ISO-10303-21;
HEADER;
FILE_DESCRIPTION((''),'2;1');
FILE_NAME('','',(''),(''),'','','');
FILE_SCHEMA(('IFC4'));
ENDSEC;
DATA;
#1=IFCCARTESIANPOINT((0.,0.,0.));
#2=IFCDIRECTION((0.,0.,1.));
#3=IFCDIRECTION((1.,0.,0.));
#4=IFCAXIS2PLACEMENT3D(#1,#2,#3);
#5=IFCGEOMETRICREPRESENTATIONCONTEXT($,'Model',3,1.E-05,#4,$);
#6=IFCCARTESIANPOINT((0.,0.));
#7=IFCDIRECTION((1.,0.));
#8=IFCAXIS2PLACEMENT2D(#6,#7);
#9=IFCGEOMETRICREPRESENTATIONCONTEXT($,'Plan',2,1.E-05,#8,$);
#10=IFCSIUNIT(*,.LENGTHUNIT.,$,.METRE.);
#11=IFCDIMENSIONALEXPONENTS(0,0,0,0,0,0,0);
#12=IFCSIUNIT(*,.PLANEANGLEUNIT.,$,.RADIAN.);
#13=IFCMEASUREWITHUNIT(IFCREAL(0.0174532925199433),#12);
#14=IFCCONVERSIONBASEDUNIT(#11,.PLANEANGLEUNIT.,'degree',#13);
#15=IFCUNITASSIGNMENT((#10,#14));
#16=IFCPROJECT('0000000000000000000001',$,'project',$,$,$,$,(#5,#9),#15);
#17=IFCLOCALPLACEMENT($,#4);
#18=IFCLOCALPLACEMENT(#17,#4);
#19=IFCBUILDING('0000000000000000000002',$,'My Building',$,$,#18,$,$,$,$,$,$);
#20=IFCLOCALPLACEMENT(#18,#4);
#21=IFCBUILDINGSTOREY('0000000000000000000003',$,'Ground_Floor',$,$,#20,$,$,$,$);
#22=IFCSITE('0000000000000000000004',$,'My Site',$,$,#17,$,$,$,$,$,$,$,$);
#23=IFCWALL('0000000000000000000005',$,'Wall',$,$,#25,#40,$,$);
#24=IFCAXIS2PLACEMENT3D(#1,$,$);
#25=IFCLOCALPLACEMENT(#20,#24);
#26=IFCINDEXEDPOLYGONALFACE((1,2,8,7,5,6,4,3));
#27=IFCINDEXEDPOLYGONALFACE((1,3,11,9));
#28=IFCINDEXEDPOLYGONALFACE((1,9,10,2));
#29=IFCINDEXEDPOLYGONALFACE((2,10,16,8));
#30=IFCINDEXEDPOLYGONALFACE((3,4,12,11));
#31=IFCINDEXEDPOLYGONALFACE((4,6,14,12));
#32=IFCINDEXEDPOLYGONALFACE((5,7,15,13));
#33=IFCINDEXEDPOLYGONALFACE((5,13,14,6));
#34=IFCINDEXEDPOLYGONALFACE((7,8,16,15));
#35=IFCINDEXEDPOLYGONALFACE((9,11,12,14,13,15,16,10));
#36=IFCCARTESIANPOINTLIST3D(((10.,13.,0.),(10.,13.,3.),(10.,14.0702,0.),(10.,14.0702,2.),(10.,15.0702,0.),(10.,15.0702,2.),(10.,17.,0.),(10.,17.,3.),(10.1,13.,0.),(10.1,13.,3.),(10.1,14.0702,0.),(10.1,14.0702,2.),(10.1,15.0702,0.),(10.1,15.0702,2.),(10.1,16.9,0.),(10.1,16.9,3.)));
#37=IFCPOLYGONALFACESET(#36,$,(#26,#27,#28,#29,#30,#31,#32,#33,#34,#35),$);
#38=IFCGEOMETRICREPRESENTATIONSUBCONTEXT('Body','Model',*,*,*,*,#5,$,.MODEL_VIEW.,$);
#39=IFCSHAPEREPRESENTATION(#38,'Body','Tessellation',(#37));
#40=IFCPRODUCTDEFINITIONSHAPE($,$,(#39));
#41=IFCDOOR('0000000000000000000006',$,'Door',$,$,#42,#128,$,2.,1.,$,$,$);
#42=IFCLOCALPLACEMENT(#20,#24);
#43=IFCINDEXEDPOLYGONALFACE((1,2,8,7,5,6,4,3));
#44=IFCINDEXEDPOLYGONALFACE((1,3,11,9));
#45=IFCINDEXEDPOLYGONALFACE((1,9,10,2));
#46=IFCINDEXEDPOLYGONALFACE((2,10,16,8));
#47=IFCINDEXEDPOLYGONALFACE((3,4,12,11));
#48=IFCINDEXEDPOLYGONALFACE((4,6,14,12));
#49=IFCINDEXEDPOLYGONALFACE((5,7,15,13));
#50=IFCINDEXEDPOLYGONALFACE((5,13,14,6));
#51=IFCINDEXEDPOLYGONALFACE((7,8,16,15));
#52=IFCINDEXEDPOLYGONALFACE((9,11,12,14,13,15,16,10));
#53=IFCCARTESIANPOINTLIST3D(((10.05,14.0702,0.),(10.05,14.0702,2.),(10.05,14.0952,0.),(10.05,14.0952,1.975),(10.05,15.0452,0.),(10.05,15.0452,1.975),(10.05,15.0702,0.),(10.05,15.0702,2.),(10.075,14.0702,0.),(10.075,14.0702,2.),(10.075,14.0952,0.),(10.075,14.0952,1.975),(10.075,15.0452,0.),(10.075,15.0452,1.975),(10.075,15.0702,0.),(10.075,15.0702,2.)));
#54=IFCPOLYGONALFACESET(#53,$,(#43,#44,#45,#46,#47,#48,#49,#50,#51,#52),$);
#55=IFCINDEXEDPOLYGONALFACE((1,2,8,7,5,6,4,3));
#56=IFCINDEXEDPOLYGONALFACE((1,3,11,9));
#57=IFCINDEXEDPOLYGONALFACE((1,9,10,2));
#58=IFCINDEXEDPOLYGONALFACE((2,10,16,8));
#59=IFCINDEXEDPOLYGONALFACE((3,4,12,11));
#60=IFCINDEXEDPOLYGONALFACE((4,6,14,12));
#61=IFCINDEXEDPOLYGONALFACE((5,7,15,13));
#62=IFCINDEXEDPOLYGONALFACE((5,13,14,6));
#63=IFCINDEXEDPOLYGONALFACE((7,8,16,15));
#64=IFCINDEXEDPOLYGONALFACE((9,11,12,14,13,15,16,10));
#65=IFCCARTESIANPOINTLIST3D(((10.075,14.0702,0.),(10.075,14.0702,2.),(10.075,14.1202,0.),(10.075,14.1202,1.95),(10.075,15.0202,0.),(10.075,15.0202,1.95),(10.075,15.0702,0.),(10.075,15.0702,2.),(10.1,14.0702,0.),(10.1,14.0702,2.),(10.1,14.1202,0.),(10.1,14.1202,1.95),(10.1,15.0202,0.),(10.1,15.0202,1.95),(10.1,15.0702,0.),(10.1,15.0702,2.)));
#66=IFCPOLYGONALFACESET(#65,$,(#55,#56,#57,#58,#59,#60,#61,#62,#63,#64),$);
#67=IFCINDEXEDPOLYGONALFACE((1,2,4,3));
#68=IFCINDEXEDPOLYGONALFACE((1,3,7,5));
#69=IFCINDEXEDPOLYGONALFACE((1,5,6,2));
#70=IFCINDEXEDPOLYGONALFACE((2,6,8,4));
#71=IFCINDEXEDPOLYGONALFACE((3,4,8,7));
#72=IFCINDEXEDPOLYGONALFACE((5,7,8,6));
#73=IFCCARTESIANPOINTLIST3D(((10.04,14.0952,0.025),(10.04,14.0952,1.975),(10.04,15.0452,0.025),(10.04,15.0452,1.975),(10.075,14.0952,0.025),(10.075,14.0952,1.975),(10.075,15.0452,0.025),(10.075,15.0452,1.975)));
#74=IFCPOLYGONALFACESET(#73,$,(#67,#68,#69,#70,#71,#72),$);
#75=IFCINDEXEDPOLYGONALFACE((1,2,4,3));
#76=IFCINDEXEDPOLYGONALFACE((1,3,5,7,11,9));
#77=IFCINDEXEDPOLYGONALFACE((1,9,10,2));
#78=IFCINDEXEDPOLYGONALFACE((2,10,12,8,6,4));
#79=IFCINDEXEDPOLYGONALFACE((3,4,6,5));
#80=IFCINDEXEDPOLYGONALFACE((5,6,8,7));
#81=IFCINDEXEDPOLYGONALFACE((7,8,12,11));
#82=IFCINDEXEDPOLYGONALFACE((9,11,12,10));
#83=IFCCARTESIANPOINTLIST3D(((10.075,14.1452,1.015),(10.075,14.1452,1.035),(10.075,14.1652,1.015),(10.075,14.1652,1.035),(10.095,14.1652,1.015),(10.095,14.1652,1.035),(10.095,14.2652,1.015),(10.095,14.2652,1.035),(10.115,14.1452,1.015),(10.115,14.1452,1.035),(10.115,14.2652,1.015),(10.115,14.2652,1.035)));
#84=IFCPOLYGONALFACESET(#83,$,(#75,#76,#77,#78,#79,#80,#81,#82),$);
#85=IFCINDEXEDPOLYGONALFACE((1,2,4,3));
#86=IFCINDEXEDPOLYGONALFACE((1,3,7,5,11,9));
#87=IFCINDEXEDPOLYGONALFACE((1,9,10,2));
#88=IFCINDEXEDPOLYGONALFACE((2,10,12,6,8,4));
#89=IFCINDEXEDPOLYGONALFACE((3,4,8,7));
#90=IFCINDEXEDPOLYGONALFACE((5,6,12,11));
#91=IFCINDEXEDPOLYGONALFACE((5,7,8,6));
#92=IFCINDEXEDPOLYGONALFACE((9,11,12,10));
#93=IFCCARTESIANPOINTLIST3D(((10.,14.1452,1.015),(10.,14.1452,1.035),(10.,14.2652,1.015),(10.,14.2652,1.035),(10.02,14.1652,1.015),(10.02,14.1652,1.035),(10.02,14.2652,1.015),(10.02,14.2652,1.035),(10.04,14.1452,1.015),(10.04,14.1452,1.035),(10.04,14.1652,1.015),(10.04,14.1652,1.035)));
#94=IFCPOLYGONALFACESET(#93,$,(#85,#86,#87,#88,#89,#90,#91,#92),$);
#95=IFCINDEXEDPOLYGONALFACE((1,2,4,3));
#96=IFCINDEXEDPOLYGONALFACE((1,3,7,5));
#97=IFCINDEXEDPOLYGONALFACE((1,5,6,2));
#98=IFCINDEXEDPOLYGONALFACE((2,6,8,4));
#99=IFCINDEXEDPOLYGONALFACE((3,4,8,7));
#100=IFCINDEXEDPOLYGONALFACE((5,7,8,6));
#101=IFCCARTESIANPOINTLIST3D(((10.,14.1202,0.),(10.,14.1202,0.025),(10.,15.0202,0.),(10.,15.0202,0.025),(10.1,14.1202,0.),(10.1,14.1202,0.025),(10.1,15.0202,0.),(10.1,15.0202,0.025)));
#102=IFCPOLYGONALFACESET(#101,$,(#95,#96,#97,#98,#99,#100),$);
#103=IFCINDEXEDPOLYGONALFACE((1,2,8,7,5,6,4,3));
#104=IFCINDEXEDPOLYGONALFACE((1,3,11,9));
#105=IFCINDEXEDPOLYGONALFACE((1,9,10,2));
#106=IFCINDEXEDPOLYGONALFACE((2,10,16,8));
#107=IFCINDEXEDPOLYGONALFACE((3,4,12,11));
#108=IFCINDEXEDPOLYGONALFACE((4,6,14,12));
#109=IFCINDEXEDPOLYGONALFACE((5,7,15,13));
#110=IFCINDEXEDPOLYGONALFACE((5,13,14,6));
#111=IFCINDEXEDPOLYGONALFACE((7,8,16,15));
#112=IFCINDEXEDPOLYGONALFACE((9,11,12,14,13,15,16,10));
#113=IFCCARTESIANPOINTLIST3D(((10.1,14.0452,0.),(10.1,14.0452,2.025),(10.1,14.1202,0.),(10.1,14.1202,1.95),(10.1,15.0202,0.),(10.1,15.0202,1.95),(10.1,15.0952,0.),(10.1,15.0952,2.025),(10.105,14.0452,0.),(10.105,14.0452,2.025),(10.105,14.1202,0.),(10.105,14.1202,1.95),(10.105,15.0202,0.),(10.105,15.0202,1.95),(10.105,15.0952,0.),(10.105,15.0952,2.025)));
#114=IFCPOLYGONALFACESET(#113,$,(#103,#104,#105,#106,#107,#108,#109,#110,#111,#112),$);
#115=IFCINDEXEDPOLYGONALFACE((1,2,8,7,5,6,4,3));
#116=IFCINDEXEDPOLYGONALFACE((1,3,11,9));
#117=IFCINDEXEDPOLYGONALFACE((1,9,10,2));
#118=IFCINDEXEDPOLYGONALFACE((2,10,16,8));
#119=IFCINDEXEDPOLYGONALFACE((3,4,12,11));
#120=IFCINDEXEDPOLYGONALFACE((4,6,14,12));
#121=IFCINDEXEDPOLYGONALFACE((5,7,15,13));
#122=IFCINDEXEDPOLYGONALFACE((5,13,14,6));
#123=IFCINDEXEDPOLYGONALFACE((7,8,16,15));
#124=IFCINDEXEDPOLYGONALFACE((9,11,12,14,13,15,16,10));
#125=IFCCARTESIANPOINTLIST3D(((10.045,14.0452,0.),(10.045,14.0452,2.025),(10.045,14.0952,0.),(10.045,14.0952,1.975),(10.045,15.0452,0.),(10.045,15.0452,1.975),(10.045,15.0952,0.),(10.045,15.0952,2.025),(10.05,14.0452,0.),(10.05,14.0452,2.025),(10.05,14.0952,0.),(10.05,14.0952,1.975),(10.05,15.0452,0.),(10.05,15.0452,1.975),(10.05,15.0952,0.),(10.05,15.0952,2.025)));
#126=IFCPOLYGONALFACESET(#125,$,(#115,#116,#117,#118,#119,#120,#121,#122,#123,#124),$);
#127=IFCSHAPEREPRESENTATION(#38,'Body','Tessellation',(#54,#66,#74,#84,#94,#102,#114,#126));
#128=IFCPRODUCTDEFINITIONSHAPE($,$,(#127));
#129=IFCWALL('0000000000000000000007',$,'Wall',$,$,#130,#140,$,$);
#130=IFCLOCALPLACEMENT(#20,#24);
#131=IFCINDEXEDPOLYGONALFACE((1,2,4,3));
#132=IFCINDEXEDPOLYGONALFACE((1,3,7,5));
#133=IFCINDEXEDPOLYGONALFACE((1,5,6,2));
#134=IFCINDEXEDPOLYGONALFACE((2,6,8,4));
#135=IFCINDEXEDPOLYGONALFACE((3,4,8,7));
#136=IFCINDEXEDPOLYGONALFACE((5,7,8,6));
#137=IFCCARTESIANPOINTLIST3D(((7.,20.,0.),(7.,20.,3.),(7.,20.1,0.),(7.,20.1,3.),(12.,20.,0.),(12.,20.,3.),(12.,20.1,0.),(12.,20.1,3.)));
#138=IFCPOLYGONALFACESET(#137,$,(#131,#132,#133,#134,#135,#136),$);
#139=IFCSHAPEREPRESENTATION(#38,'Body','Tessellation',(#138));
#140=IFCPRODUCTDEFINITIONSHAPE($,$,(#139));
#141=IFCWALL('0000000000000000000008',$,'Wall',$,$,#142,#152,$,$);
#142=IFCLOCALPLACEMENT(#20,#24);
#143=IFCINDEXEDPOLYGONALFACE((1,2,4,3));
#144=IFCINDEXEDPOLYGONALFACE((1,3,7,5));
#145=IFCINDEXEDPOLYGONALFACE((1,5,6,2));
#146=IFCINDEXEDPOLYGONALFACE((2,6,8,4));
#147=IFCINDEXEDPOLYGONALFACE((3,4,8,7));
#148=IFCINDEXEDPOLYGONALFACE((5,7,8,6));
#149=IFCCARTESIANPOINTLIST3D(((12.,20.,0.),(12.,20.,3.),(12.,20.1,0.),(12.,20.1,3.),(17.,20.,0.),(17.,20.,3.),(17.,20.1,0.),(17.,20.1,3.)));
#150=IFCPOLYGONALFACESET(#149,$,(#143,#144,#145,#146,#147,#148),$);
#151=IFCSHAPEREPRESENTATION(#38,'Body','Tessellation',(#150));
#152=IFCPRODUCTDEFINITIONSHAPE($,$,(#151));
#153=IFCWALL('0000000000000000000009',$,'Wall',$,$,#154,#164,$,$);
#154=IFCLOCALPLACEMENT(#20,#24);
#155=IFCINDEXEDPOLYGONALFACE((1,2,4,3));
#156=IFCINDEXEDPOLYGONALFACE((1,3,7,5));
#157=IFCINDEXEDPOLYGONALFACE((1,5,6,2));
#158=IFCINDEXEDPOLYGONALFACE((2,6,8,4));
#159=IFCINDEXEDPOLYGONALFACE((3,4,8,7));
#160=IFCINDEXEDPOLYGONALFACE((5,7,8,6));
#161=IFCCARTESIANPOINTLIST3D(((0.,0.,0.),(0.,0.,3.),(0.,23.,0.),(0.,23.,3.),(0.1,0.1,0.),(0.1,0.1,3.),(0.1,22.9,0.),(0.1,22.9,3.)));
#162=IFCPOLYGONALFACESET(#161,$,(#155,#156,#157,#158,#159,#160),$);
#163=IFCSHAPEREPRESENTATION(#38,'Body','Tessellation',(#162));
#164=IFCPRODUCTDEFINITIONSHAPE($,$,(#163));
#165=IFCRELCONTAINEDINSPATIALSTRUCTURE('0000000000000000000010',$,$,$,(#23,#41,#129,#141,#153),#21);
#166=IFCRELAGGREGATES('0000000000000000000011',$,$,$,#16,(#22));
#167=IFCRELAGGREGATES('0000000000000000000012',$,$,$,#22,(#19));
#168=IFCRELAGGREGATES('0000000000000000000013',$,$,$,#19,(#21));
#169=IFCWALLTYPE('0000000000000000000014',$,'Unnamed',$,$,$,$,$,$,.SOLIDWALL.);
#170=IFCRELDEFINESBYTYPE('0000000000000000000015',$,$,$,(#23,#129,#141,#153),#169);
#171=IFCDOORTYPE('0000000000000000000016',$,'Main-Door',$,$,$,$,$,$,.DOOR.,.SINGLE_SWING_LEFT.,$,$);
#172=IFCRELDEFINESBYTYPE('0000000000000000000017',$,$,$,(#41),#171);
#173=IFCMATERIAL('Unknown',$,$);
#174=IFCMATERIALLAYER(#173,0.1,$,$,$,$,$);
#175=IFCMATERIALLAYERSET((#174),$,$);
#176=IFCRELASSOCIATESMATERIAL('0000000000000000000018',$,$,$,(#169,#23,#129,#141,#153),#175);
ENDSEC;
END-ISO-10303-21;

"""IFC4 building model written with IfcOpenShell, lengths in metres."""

from ifc_helpers import new_model, entity, si_unit, converted_unit, frame, origin_with_axes, origin_2d_with_axis, place, context, subcontext, project, spatial, line, indexed_curve, outline, extrude, shape, source, transform, mapped, material, layer, layer_set, layer_usage, type_object, type_shapes, element, fill, save


model = new_model("IFC4")

# Units and contexts
model_context = context("Model", 3, precision=1e-05, world=origin_with_axes())
plan_context = context("Plan", 2, precision=1e-05, world=origin_2d_with_axis())
body_context_1 = subcontext(model_context, "Body", "Model", "MODEL_VIEW")
body_context_2 = subcontext(plan_context, "Body", "Plan", "PLAN_VIEW")
ifc_project = project(units=[si_unit("LENGTHUNIT", "METRE"), converted_unit("PLANEANGLEUNIT", "degree", entity("IfcReal", 0.0174532925199433), si_unit("PLANEANGLEUNIT", "RADIAN"), dimensions=[0, 0, 0, 0, 0, 0, 0])], contexts=[model_context, plan_context])

# Site, building, storey
site_placement = place(None, origin_with_axes())
site = spatial("IfcSite", under=ifc_project, at=site_placement, Name="My Site")
building_placement = place(site_placement, origin_with_axes())
building = spatial("IfcBuilding", under=site, at=building_placement, Name="My Building")
storey_placement = place(building_placement, origin_with_axes())
storey = spatial("IfcBuildingStorey", under=building, at=storey_placement, Name="Ground_Floor")

# Shared definitions
ifc_material = material(Name="Unknown")

# Shared definitions
ifc_layer_1 = layer(ifc_material, 0.1)
ifc_layer_set_1 = layer_set([ifc_layer_1])
wall_type = type_object("IfcWallType", Name="Unnamed", PredefinedType="SOLIDWALL", material=ifc_layer_set_1)

# Shared definitions
shared_shape_1 = source(origin_with_axes(), body_context_1, "Body", "SweptSolid", [
    extrude(outline(indexed_curve([(0.0, 0.0), (1.0, 0.0), (1.0, 2.0), (0.0, 2.0)], segments=[line(1, 2, 3, 4, 1)])), frame((0.0, -0.6, 0.0), z_axis=(0.0, -1.0, 0.0), x_axis=(1.0, 0.0, 0.0)), (0.0, 0.0, -1.0), 1.2),
])
door_type = type_object("IfcDoorType", Name="Main-Door", OperationType="SINGLE_SWING_LEFT", PredefinedType="DOOR")
shared_shape_2 = source(origin_with_axes(), body_context_1, "Body", "SweptSolid", [
    extrude(outline(indexed_curve([(0.0, 0.0), (0.0, 2.0), (1.0, 2.0), (1.0, 0.0), (0.975, 0.0), (0.975, 1.975), (0.025, 1.975), (0.025, 0.0)], segments=[line(1, 2, 3, 4, 5, 6, 7, 8, 1)])), frame((0.0, 0.025, 0.0), z_axis=(0.0, -1.0, 0.0), x_axis=(1.0, 0.0, 0.0)), (0.0, 0.0, -1.0), 0.025),
    extrude(outline(indexed_curve([(0.0, 0.0), (0.0, 2.0), (1.0, 2.0), (1.0, 0.0), (0.95, 0.0), (0.95, 1.95), (0.05, 1.95), (0.05, 0.0)], segments=[line(1, 2, 3, 4, 5, 6, 7, 8, 1)])), frame((0.0, 0.0, 0.0), z_axis=(0.0, -1.0, 0.0), x_axis=(1.0, 0.0, 0.0)), (0.0, 0.0, -1.0), 0.025),
    extrude(outline(indexed_curve([(0.0, 0.0), (0.95, 0.0), (0.95, 0.035), (0.0, 0.035)], segments=[line(1, 2, 3, 4, 1)])), frame((0.025, 0.025, 0.025), z_axis=(0.0, 0.0, 1.0), x_axis=(1.0, 0.0, 0.0)), (0.0, 0.0, 1.0), 1.95),
    extrude(outline(indexed_curve([(0.0, 0.0), (0.0, -0.04), (0.12, -0.04), (0.12, -0.02), (0.02, -0.02), (0.02, 0.0)], segments=[line(1, 2, 3, 4, 5, 6, 1)])), frame((0.075, 0.025, 1.015), z_axis=(0.0, 0.0, 1.0), x_axis=(1.0, 0.0, 0.0)), (0.0, 0.0, 1.0), 0.02),
    extrude(outline(indexed_curve([(0.0, 0.0), (0.0, 0.04), (0.12, 0.04), (0.12, 0.02), (0.02, 0.02), (0.02, 0.0)], segments=[line(1, 2, 3, 4, 5, 6, 1)])), frame((0.075, 0.06, 1.015), z_axis=(0.0, 0.0, 1.0), x_axis=(1.0, 0.0, 0.0)), (0.0, 0.0, 1.0), 0.02),
    extrude(outline(indexed_curve([(0.0, 0.0), (0.9, 0.0), (0.9, 0.1), (0.0, 0.1)], segments=[line(1, 2, 3, 4, 1)])), frame((0.05, 0.0, 0.0), z_axis=(0.0, 0.0, 1.0), x_axis=(1.0, 0.0, 0.0)), (0.0, 0.0, 1.0), 0.025),
    extrude(outline(indexed_curve([(0.0, 0.0), (0.0, 2.025), (1.05, 2.025), (1.05, 0.0), (0.975, 0.0), (0.975, 1.95), (0.075, 1.95), (0.075, 0.0)], segments=[line(1, 2, 3, 4, 5, 6, 7, 8, 1)])), frame((-0.025, -0.005, 0.0), z_axis=(0.0, -1.0, 0.0), x_axis=(1.0, 0.0, 0.0)), (0.0, 0.0, -1.0), 0.005),
    extrude(outline(indexed_curve([(0.0, 0.0), (0.0, 2.025), (1.05, 2.025), (1.05, 0.0), (1.0, 0.0), (1.0, 1.975), (0.05, 1.975), (0.05, 0.0)], segments=[line(1, 2, 3, 4, 5, 6, 7, 8, 1)])), frame((-0.025, 0.05, 0.0), z_axis=(0.0, -1.0, 0.0), x_axis=(1.0, 0.0, 0.0)), (0.0, 0.0, -1.0), 0.005),
])
shared_shape_3 = source(origin_with_axes(), body_context_2, "Body", "Curve2D", [
    entity("IfcIndexedPolyCurve", entity("IfcCartesianPointList2D", [[0.0, 0.0], [0.0, 0.05], [0.025, 0.05], [0.025, 0.025], [0.05, 0.025], [0.05, 0.0]]), [entity("IfcLineIndex", [1, 2, 3, 4, 5, 6, 1])]),
    entity("IfcIndexedPolyCurve", entity("IfcCartesianPointList2D", [[1.0, 0.0], [1.0, 0.05], [0.975, 0.05], [0.975, 0.025], [0.95, 0.025], [0.95, 0.0]]), [entity("IfcLineIndex", [1, 2, 3, 4, 5, 6, 1])]),
    entity("IfcTrimmedCurve", entity("IfcEllipse", entity("IfcAxis2Placement2D", entity("IfcCartesianPoint", [0.94, 0.05]), entity("IfcDirection", [1.0, 0.0])), 0.915, 0.95), [entity("IfcCartesianPoint", [0.94, 1.0])], [entity("IfcCartesianPoint", [0.025, 0.05])], True, "CARTESIAN"),
    entity("IfcIndexedPolyCurve", entity("IfcCartesianPointList2D", [[0.975, 0.05], [0.94, 0.05], [0.94, 1.0], [0.975, 1.0]]), [entity("IfcLineIndex", [1, 2, 3, 4, 1])]),
])
type_shapes(door_type, [shared_shape_2, shared_shape_3])

# Wall, opening, door
ifc_layer_usage_1 = layer_usage(ifc_layer_set_1, "AXIS2", "POSITIVE", 0.0)
wall_1_placement = place(storey_placement, frame((10.0, 17.0, 0.0), z_axis=(0.0, 0.0, 1.0), x_axis=(0.0, -1.0, 0.0)))
wall_1 = element("IfcWall", 1, at=wall_1_placement, inside=storey, type_object=wall_type, material=ifc_layer_usage_1, Name="Wall", context=body_context_1, shape_type="SweptSolid", body=[
    extrude(outline(indexed_curve([(0.0, 0.0), (0.1, 0.1), (4.0, 0.1), (4.0, 0.0)], segments=[line(1, 2, 3, 4, 1)])), origin_with_axes(), (0.0, 0.0, 1.0), 3.0),
])
opening_1_placement = place(wall_1_placement, frame((2.9298, 0.1, 0.0), z_axis=(0.0, 0.0, 1.0), x_axis=(-1.0, 0.0, 0.0)))
opening_1 = element("IfcOpeningElement", 2, at=opening_1_placement, cuts=wall_1, PredefinedType="OPENING", context=body_context_1, shape_type="MappedRepresentation", body=[
    mapped(shared_shape_1, transform((0.0, 0.0, 0.0), x_axis=(1.0, 0.0, 0.0), y_axis=(0.0, 1.0, 0.0), z_axis=(0.0, 0.0, 1.0), scale=1.0)),
])
door_1_placement = place(opening_1_placement, frame((0.0, 0.0, 0.0), z_axis=(0.0, 0.0, 1.0), x_axis=(1.0, 0.0, 0.0)))
door_1 = element("IfcDoor", 3, at=door_1_placement, inside=storey, type_object=door_type, Name="Door", OverallHeight=2.0, OverallWidth=1.0, shapes=[
    shape(body_context_1, "Body", "MappedRepresentation", [mapped(shared_shape_2, transform((0.0, 0.0, 0.0), x_axis=(1.0, 0.0, 0.0), y_axis=(0.0, 1.0, 0.0), z_axis=(0.0, 0.0, 1.0), scale=1.0))]),
    shape(body_context_2, "Body", "MappedRepresentation", [mapped(shared_shape_3, transform((0.0, 0.0, 0.0), x_axis=(1.0, 0.0, 0.0), y_axis=(0.0, 1.0, 0.0), z_axis=(0.0, 0.0, 1.0), scale=1.0))]),
])
fill(opening_1, door_1)

# Walls
ifc_layer_usage_2 = layer_usage(ifc_layer_set_1, "AXIS2", "POSITIVE", 0.0)
wall_2_placement = place(storey_placement, frame((7.0, 20.0, 0.0), z_axis=(0.0, 0.0, 1.0), x_axis=(1.0, 0.0, 0.0)))
element("IfcWall", 4, at=wall_2_placement, inside=storey, type_object=wall_type, material=ifc_layer_usage_2, Name="Wall", context=body_context_1, shape_type="SweptSolid", body=[
    extrude(outline(indexed_curve([(0.0, 0.0), (0.0, 0.1), (5.0, 0.1), (5.0, 0.0)], segments=[line(1, 2, 3, 4, 1)])), origin_with_axes(), (0.0, 0.0, 1.0), 3.0),
])
ifc_layer_usage_3 = layer_usage(ifc_layer_set_1, "AXIS2", "POSITIVE", 0.0)
wall_3_placement = place(storey_placement, frame((12.0, 20.0, 0.0), z_axis=(0.0, 0.0, 1.0), x_axis=(1.0, 0.0, 0.0)))
element("IfcWall", 5, at=wall_3_placement, inside=storey, type_object=wall_type, material=ifc_layer_usage_3, Name="Wall", context=body_context_1, shape_type="SweptSolid", body=[
    extrude(outline(indexed_curve([(0.0, 0.0), (0.0, 0.1), (5.0, 0.1), (5.0, 0.0)], segments=[line(1, 2, 3, 4, 1)])), origin_with_axes(), (0.0, 0.0, 1.0), 3.0),
])
ifc_layer_usage_4 = layer_usage(ifc_layer_set_1, "AXIS2", "POSITIVE", 0.0)
wall_4_placement = place(storey_placement, frame((0.0, 23.0, 0.0), z_axis=(0.0, 0.0, 1.0), x_axis=(0.0, -1.0, 0.0)))
element("IfcWall", 6, at=wall_4_placement, inside=storey, type_object=wall_type, material=ifc_layer_usage_4, Name="Wall", context=body_context_1, shape_type="SweptSolid", body=[
    extrude(outline(indexed_curve([(0.0, 0.0), (0.1, 0.1), (22.9, 0.1), (23.0, 0.0)], segments=[line(1, 2, 3, 4, 1)])), origin_with_axes(), (0.0, 0.0, 1.0), 3.0),
])

save(model, "model.ifc")
